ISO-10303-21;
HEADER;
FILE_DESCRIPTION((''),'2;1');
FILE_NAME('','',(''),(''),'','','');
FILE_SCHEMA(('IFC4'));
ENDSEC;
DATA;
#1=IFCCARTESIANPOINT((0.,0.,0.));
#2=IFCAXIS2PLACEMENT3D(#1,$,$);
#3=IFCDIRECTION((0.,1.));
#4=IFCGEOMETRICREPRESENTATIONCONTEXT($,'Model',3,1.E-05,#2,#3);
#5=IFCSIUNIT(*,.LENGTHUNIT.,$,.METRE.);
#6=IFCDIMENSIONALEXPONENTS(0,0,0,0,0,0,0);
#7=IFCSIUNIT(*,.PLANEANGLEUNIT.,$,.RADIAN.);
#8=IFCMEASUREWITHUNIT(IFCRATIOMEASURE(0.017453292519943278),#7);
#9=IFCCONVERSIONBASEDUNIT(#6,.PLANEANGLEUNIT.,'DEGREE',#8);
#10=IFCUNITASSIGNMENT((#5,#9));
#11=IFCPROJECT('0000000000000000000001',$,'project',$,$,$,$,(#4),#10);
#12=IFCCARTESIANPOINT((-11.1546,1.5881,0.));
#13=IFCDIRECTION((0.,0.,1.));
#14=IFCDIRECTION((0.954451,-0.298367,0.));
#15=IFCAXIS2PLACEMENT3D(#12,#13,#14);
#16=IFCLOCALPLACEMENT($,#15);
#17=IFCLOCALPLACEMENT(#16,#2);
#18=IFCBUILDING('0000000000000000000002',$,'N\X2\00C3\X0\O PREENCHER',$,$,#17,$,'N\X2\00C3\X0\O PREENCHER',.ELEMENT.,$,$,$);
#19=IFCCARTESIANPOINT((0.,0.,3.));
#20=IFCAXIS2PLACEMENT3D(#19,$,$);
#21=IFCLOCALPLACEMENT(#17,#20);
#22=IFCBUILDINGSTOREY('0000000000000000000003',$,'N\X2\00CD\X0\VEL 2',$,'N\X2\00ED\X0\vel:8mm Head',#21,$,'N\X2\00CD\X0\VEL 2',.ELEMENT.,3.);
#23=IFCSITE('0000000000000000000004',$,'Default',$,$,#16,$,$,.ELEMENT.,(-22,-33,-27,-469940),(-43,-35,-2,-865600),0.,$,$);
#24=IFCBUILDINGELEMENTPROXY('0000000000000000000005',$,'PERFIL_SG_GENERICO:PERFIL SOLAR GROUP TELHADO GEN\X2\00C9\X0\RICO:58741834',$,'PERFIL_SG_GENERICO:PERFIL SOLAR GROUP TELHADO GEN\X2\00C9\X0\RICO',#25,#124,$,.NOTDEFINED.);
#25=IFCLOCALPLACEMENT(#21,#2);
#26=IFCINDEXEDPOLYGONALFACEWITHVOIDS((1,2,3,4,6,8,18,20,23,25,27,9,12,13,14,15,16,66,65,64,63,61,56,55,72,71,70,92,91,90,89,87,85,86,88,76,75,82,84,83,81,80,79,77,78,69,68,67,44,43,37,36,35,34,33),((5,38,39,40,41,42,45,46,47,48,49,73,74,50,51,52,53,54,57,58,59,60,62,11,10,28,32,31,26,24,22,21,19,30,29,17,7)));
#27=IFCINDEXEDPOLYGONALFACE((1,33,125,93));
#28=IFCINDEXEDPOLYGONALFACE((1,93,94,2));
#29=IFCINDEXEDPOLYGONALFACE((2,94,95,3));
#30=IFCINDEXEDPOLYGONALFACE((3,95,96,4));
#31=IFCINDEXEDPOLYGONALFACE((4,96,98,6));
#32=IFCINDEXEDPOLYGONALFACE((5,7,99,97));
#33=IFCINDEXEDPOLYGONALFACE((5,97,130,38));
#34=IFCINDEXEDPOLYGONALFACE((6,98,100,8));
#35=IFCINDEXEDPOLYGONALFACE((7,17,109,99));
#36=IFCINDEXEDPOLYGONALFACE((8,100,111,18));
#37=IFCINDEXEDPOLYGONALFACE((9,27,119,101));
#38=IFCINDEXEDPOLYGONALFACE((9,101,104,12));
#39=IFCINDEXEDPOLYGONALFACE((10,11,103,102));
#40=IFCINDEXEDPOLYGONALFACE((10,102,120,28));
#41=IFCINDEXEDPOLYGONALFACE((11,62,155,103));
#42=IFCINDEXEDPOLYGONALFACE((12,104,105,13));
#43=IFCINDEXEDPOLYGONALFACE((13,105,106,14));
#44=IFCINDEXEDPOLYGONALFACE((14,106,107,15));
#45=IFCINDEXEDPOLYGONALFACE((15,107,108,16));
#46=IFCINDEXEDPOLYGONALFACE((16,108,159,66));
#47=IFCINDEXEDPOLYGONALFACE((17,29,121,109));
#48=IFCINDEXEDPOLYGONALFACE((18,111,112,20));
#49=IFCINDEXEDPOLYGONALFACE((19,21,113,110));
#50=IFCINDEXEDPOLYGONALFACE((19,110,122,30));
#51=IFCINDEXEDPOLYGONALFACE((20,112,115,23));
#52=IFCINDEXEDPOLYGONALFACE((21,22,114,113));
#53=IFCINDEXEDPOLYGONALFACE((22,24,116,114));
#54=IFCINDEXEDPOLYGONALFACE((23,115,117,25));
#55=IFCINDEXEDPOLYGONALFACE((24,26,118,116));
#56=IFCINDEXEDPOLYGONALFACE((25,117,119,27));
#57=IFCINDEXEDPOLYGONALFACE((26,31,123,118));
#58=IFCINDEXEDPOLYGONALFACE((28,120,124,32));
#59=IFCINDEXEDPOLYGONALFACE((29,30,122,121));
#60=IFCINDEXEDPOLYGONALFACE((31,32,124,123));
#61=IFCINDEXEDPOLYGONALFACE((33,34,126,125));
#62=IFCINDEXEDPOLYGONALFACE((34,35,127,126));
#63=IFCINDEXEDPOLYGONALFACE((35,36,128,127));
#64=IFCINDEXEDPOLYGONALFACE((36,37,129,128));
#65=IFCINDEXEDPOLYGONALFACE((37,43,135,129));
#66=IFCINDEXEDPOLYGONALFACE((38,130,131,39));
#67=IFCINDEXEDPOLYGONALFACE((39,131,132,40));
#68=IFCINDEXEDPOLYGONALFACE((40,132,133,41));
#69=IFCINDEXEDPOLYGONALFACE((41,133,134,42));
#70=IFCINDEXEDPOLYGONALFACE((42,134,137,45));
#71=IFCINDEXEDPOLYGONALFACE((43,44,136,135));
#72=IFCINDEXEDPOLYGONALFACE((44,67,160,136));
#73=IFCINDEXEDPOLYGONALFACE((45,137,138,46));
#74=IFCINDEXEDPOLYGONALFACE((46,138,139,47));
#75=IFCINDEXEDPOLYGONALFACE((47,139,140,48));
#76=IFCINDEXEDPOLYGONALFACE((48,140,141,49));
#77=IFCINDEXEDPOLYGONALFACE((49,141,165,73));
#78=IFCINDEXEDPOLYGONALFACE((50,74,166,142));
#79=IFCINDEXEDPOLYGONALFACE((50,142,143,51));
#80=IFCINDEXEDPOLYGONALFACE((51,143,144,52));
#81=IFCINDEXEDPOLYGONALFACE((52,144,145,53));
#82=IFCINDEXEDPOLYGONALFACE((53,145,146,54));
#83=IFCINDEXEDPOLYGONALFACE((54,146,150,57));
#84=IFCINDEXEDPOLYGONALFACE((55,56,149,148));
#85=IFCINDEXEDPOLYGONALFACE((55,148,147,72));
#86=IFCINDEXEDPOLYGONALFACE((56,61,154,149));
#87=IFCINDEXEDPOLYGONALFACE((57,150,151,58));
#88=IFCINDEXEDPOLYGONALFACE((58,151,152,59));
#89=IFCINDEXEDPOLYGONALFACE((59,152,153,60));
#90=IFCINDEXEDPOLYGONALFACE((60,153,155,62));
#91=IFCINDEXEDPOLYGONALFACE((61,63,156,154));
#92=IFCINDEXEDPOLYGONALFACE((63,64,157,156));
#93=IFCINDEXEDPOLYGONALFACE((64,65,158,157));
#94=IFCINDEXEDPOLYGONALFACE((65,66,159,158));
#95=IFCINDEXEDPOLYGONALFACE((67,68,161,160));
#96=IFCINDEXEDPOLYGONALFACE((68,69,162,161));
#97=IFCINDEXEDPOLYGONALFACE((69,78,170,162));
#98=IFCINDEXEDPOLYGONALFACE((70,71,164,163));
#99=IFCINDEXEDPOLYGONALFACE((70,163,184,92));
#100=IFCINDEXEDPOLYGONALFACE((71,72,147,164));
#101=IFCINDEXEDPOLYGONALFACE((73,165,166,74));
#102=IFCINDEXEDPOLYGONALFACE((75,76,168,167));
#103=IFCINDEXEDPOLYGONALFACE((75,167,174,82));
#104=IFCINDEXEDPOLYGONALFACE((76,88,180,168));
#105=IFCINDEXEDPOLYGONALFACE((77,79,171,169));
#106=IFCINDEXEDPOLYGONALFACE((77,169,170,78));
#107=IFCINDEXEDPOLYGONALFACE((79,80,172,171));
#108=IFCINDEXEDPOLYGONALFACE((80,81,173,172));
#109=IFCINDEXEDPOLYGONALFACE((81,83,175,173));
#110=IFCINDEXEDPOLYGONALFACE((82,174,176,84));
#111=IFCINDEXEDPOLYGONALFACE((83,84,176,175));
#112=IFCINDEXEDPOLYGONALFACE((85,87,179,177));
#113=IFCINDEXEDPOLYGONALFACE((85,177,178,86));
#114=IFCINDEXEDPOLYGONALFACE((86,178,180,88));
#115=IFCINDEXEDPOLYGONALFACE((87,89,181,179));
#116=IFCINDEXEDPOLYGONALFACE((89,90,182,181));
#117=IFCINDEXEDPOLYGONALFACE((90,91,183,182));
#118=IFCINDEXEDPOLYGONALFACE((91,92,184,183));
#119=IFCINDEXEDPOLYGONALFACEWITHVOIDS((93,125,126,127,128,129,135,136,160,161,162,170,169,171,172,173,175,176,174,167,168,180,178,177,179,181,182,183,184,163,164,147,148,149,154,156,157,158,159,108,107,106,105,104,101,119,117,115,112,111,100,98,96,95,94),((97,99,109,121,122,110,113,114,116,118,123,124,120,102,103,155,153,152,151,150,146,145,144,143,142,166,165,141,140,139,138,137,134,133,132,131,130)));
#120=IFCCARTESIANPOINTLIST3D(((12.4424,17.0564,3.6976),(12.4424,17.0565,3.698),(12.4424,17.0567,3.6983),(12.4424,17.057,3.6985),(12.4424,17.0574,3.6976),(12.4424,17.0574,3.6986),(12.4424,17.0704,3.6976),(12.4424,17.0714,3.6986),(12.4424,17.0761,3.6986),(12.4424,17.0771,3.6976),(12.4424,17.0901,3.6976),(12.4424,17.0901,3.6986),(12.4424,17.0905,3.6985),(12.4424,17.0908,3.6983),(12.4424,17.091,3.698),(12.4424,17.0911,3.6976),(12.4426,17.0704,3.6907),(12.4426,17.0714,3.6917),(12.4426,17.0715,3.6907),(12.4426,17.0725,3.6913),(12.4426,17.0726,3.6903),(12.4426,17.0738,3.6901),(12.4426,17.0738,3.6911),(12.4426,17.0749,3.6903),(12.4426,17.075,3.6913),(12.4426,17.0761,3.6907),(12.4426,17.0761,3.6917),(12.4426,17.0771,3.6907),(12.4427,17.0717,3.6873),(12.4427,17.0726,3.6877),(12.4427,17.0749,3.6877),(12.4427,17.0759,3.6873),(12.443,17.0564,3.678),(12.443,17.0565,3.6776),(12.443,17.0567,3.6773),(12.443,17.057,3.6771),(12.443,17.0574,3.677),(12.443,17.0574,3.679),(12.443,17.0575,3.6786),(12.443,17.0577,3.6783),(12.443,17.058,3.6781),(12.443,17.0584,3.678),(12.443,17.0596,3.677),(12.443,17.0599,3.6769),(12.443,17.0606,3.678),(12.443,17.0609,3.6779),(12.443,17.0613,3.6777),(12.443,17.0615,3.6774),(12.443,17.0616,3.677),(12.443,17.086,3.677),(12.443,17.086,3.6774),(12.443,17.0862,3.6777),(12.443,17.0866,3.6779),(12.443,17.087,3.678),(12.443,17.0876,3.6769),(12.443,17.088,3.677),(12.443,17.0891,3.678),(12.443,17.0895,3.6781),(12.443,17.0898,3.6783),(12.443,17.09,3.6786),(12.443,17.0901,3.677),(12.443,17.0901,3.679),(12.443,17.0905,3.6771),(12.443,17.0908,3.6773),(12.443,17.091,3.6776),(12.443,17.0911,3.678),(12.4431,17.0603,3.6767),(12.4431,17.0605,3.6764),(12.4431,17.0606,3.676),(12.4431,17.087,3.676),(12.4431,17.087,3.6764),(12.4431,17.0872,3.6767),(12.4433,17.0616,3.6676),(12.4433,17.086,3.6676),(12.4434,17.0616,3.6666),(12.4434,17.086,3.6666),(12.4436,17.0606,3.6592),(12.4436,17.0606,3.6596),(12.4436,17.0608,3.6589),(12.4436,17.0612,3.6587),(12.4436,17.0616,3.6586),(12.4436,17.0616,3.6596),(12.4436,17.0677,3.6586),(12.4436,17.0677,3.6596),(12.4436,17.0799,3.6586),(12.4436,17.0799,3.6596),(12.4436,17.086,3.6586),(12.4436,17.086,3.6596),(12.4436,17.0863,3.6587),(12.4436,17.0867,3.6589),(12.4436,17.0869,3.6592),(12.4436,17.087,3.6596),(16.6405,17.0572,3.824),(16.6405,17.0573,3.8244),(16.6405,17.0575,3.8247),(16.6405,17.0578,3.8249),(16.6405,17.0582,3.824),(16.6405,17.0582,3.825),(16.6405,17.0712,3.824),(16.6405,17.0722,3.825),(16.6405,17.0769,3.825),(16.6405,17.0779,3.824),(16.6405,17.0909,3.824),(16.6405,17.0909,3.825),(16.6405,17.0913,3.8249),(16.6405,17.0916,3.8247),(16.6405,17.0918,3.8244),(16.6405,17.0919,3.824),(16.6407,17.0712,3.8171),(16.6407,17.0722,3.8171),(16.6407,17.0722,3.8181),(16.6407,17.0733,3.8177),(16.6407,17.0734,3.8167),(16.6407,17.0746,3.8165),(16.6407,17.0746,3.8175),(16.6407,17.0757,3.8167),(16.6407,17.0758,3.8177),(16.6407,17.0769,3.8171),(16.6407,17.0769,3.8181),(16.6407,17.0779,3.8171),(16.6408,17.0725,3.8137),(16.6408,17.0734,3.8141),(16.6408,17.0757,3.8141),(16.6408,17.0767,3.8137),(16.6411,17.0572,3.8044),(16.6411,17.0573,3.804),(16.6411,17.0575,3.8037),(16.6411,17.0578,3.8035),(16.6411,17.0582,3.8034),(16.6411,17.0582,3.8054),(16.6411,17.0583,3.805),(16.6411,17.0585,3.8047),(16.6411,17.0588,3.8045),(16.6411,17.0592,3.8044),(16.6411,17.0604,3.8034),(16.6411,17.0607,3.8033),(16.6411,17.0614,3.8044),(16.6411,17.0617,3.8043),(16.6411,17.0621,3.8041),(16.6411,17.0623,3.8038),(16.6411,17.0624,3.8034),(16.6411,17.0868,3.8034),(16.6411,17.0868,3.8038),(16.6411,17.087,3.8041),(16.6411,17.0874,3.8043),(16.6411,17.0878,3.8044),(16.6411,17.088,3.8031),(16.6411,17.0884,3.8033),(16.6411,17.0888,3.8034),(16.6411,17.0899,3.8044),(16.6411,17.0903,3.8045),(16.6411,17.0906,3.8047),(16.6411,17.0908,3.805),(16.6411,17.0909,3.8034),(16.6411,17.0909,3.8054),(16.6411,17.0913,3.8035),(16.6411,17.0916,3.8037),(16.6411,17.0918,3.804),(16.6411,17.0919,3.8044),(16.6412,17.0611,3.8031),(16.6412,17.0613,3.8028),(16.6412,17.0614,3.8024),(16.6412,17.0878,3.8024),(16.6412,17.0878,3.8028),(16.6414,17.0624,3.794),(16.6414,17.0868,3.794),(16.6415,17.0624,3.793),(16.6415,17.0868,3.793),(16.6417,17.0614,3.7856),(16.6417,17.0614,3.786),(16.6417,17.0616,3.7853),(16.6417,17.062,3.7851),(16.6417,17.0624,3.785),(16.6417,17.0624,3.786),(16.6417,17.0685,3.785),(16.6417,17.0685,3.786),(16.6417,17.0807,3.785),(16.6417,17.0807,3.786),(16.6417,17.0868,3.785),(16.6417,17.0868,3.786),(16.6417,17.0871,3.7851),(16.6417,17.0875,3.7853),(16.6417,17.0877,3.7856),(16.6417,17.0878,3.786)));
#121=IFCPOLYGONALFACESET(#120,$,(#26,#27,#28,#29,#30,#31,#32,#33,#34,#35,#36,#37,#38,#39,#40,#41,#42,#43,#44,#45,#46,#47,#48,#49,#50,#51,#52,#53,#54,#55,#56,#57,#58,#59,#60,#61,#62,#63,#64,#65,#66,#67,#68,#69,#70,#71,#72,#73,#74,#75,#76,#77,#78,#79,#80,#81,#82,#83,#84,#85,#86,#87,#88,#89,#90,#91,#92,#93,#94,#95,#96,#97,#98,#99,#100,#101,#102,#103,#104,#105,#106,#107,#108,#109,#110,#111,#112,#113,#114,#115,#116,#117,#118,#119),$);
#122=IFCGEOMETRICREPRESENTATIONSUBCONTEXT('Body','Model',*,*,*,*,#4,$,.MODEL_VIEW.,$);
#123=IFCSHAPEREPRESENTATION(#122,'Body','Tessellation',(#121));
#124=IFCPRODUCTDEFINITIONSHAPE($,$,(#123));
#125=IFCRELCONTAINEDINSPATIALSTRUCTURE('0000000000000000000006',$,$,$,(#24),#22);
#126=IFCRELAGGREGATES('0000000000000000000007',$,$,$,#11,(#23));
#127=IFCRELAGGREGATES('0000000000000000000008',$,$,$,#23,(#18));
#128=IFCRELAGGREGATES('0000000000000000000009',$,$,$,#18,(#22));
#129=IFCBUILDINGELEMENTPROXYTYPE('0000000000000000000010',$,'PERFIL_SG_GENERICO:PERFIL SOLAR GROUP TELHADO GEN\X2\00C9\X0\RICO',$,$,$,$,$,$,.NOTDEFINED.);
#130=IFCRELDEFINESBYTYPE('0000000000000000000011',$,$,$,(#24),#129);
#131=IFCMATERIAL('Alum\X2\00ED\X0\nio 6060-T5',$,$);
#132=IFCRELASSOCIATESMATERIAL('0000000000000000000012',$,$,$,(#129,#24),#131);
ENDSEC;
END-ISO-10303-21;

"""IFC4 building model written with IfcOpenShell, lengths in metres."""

from ifc_helpers import new_model, entity, si_unit, converted_unit, direction, frame, origin, place, context, subcontext, project, spatial, line, arc, indexed_curve, outline, extrude, source, transform, mapped, material, type_object, type_shapes, element, save


model = new_model("IFC4")

# Units and contexts
model_context = context("Model", 3, precision=1e-05, world=origin(), true_north=direction((0.0, 1.0)))
body_context = subcontext(model_context, "Body", "Model", "MODEL_VIEW")
ifc_project = project(units=[si_unit("LENGTHUNIT", "METRE"), converted_unit("PLANEANGLEUNIT", "DEGREE", entity("IfcRatioMeasure", 0.017453292519943278), si_unit("PLANEANGLEUNIT", "RADIAN"), dimensions=[0, 0, 0, 0, 0, 0, 0])], contexts=[model_context])

# Site, building, storey
site_placement = place(None, frame((-11.1546, 1.5881, 0.0), z_axis=(0.0, 0.0, 1.0), x_axis=(0.954451, -0.298367, 0.0)))
site = spatial("IfcSite", under=ifc_project, at=site_placement, Name="Default", CompositionType="ELEMENT", RefLatitude=(-22, -33, -27, -469940), RefLongitude=(-43, -35, -2, -865600), RefElevation=0.0)
building_placement = place(site_placement, origin())
building = spatial("IfcBuilding", under=site, at=building_placement, Name="NÃO PREENCHER", LongName="NÃO PREENCHER", CompositionType="ELEMENT")
storey_placement = place(building_placement, frame((0.0, 0.0, 3.0)))
storey = spatial("IfcBuildingStorey", under=building, at=storey_placement, Name="NÍVEL 2", ObjectType="Nível:8mm Head", LongName="NÍVEL 2", CompositionType="ELEMENT", Elevation=3.0)

# Building element proxy
ifc_material_1 = material(Name="Alumínio 6060-T5")
building_element_proxy_type_1 = type_object("IfcBuildingElementProxyType", Name="PERFIL_SG_GENERICO:PERFIL SOLAR GROUP TELHADO GENÉRICO", PredefinedType="NOTDEFINED", material=ifc_material_1)
shared_shape_1 = source(origin(), body_context, "Body", "SweptSolid", [
    extrude(outline(indexed_curve([(-0.0122, -0.0169), (-0.0061, -0.0169), (-0.0061, -0.0159), (-0.0122, -0.0159), (-0.0122, -0.0089), (0.0122, -0.0089), (0.0122, -0.0159), (0.0061, -0.0159), (0.0061, -0.0169), (0.0122, -0.0169), (0.0129, -0.0166), (0.0132, -0.0159), (0.0132, 0.0005), (0.0135, 0.0012), (0.0142, 0.0015), (0.0164, 0.0015), (0.0171, 0.0018), (0.0174, 0.0025), (0.0174, 0.0221), (0.0171, 0.0228), (0.0164, 0.0231), (0.0024, 0.0231), (0.0024, 0.0162), (0.0, 0.0156), (-0.0024, 0.0162), (-0.0024, 0.0231), (-0.0164, 0.0231), (-0.0171, 0.0228), (-0.0174, 0.0221), (-0.0174, 0.0025), (-0.0171, 0.0018), (-0.0164, 0.0015), (-0.0142, 0.0015), (-0.0135, 0.0012), (-0.0132, 0.0005), (-0.0132, -0.0159), (-0.0129, -0.0166)], segments=[line(1, 2, 3, 4, 5, 6, 7, 8, 9, 10), arc(10, 11, 12), line(12, 13), arc(13, 14, 15), line(15, 16), arc(16, 17, 18), line(18, 19), arc(19, 20, 21), line(21, 22, 23), arc(23, 24, 25), line(25, 26, 27), arc(27, 28, 29), line(29, 30), arc(30, 31, 32), line(32, 33), arc(33, 34, 35), line(35, 36), arc(36, 37, 1)], self_intersect=False), holes=[indexed_curve([(-0.0122, -0.0079), (-0.0122, 0.0015), (-0.0125, 0.0022), (-0.0132, 0.0025), (-0.0154, 0.0025), (-0.0161, 0.0028), (-0.0164, 0.0035), (-0.0164, 0.0221), (-0.0034, 0.0221), (-0.0034, 0.0152), (-0.0021, 0.0118), (-0.0012, 0.0122), (-0.0023, 0.0151), (0.0, 0.0146), (0.0023, 0.0151), (0.0012, 0.0122), (0.0021, 0.0118), (0.0034, 0.0152), (0.0034, 0.0221), (0.0164, 0.0221), (0.0164, 0.0035), (0.0161, 0.0028), (0.0154, 0.0025), (0.0132, 0.0025), (0.0125, 0.0022), (0.0122, 0.0015), (0.0122, -0.0079)], segments=[line(1, 2), arc(2, 3, 4), line(4, 5), arc(5, 6, 7), line(7, 8, 9, 10, 11, 12, 13), arc(13, 14, 15), line(15, 16, 17, 18, 19, 20, 21), arc(21, 22, 23), line(23, 24), arc(24, 25, 26), line(26, 27, 1)], self_intersect=False)]), frame((0.0, 0.0, 0.0169), z_axis=(1.0, 0.0, 0.0), x_axis=(0.0, 1.0, 0.0)), (0.0, 0.0, 1.0), 4.2),
])
type_shapes(building_element_proxy_type_1, [shared_shape_1])
for number, where, z_axis, x_axis, name in (
    (1, (12.4436, 17.0738, 3.6586), (-0.030095, 0.0, 0.999547), (0.999547, 0.00019, 0.030095), "PERFIL_SG_GENERICO:PERFIL SOLAR GROUP TELHADO GENÉRICO:58741834"),
):
    element("IfcBuildingElementProxy", number, at=place(storey_placement, frame(where, z_axis=z_axis, x_axis=x_axis)), inside=storey, type_object=building_element_proxy_type_1, material=ifc_material_1, Name=name, ObjectType="PERFIL_SG_GENERICO:PERFIL SOLAR GROUP TELHADO GENÉRICO", PredefinedType="NOTDEFINED", context=body_context, shape_type="MappedRepresentation", body=[
        mapped(shared_shape_1, transform((0.0, 0.0, 0.0), scale=1.0)),
    ])

save(model, "model.ifc")
